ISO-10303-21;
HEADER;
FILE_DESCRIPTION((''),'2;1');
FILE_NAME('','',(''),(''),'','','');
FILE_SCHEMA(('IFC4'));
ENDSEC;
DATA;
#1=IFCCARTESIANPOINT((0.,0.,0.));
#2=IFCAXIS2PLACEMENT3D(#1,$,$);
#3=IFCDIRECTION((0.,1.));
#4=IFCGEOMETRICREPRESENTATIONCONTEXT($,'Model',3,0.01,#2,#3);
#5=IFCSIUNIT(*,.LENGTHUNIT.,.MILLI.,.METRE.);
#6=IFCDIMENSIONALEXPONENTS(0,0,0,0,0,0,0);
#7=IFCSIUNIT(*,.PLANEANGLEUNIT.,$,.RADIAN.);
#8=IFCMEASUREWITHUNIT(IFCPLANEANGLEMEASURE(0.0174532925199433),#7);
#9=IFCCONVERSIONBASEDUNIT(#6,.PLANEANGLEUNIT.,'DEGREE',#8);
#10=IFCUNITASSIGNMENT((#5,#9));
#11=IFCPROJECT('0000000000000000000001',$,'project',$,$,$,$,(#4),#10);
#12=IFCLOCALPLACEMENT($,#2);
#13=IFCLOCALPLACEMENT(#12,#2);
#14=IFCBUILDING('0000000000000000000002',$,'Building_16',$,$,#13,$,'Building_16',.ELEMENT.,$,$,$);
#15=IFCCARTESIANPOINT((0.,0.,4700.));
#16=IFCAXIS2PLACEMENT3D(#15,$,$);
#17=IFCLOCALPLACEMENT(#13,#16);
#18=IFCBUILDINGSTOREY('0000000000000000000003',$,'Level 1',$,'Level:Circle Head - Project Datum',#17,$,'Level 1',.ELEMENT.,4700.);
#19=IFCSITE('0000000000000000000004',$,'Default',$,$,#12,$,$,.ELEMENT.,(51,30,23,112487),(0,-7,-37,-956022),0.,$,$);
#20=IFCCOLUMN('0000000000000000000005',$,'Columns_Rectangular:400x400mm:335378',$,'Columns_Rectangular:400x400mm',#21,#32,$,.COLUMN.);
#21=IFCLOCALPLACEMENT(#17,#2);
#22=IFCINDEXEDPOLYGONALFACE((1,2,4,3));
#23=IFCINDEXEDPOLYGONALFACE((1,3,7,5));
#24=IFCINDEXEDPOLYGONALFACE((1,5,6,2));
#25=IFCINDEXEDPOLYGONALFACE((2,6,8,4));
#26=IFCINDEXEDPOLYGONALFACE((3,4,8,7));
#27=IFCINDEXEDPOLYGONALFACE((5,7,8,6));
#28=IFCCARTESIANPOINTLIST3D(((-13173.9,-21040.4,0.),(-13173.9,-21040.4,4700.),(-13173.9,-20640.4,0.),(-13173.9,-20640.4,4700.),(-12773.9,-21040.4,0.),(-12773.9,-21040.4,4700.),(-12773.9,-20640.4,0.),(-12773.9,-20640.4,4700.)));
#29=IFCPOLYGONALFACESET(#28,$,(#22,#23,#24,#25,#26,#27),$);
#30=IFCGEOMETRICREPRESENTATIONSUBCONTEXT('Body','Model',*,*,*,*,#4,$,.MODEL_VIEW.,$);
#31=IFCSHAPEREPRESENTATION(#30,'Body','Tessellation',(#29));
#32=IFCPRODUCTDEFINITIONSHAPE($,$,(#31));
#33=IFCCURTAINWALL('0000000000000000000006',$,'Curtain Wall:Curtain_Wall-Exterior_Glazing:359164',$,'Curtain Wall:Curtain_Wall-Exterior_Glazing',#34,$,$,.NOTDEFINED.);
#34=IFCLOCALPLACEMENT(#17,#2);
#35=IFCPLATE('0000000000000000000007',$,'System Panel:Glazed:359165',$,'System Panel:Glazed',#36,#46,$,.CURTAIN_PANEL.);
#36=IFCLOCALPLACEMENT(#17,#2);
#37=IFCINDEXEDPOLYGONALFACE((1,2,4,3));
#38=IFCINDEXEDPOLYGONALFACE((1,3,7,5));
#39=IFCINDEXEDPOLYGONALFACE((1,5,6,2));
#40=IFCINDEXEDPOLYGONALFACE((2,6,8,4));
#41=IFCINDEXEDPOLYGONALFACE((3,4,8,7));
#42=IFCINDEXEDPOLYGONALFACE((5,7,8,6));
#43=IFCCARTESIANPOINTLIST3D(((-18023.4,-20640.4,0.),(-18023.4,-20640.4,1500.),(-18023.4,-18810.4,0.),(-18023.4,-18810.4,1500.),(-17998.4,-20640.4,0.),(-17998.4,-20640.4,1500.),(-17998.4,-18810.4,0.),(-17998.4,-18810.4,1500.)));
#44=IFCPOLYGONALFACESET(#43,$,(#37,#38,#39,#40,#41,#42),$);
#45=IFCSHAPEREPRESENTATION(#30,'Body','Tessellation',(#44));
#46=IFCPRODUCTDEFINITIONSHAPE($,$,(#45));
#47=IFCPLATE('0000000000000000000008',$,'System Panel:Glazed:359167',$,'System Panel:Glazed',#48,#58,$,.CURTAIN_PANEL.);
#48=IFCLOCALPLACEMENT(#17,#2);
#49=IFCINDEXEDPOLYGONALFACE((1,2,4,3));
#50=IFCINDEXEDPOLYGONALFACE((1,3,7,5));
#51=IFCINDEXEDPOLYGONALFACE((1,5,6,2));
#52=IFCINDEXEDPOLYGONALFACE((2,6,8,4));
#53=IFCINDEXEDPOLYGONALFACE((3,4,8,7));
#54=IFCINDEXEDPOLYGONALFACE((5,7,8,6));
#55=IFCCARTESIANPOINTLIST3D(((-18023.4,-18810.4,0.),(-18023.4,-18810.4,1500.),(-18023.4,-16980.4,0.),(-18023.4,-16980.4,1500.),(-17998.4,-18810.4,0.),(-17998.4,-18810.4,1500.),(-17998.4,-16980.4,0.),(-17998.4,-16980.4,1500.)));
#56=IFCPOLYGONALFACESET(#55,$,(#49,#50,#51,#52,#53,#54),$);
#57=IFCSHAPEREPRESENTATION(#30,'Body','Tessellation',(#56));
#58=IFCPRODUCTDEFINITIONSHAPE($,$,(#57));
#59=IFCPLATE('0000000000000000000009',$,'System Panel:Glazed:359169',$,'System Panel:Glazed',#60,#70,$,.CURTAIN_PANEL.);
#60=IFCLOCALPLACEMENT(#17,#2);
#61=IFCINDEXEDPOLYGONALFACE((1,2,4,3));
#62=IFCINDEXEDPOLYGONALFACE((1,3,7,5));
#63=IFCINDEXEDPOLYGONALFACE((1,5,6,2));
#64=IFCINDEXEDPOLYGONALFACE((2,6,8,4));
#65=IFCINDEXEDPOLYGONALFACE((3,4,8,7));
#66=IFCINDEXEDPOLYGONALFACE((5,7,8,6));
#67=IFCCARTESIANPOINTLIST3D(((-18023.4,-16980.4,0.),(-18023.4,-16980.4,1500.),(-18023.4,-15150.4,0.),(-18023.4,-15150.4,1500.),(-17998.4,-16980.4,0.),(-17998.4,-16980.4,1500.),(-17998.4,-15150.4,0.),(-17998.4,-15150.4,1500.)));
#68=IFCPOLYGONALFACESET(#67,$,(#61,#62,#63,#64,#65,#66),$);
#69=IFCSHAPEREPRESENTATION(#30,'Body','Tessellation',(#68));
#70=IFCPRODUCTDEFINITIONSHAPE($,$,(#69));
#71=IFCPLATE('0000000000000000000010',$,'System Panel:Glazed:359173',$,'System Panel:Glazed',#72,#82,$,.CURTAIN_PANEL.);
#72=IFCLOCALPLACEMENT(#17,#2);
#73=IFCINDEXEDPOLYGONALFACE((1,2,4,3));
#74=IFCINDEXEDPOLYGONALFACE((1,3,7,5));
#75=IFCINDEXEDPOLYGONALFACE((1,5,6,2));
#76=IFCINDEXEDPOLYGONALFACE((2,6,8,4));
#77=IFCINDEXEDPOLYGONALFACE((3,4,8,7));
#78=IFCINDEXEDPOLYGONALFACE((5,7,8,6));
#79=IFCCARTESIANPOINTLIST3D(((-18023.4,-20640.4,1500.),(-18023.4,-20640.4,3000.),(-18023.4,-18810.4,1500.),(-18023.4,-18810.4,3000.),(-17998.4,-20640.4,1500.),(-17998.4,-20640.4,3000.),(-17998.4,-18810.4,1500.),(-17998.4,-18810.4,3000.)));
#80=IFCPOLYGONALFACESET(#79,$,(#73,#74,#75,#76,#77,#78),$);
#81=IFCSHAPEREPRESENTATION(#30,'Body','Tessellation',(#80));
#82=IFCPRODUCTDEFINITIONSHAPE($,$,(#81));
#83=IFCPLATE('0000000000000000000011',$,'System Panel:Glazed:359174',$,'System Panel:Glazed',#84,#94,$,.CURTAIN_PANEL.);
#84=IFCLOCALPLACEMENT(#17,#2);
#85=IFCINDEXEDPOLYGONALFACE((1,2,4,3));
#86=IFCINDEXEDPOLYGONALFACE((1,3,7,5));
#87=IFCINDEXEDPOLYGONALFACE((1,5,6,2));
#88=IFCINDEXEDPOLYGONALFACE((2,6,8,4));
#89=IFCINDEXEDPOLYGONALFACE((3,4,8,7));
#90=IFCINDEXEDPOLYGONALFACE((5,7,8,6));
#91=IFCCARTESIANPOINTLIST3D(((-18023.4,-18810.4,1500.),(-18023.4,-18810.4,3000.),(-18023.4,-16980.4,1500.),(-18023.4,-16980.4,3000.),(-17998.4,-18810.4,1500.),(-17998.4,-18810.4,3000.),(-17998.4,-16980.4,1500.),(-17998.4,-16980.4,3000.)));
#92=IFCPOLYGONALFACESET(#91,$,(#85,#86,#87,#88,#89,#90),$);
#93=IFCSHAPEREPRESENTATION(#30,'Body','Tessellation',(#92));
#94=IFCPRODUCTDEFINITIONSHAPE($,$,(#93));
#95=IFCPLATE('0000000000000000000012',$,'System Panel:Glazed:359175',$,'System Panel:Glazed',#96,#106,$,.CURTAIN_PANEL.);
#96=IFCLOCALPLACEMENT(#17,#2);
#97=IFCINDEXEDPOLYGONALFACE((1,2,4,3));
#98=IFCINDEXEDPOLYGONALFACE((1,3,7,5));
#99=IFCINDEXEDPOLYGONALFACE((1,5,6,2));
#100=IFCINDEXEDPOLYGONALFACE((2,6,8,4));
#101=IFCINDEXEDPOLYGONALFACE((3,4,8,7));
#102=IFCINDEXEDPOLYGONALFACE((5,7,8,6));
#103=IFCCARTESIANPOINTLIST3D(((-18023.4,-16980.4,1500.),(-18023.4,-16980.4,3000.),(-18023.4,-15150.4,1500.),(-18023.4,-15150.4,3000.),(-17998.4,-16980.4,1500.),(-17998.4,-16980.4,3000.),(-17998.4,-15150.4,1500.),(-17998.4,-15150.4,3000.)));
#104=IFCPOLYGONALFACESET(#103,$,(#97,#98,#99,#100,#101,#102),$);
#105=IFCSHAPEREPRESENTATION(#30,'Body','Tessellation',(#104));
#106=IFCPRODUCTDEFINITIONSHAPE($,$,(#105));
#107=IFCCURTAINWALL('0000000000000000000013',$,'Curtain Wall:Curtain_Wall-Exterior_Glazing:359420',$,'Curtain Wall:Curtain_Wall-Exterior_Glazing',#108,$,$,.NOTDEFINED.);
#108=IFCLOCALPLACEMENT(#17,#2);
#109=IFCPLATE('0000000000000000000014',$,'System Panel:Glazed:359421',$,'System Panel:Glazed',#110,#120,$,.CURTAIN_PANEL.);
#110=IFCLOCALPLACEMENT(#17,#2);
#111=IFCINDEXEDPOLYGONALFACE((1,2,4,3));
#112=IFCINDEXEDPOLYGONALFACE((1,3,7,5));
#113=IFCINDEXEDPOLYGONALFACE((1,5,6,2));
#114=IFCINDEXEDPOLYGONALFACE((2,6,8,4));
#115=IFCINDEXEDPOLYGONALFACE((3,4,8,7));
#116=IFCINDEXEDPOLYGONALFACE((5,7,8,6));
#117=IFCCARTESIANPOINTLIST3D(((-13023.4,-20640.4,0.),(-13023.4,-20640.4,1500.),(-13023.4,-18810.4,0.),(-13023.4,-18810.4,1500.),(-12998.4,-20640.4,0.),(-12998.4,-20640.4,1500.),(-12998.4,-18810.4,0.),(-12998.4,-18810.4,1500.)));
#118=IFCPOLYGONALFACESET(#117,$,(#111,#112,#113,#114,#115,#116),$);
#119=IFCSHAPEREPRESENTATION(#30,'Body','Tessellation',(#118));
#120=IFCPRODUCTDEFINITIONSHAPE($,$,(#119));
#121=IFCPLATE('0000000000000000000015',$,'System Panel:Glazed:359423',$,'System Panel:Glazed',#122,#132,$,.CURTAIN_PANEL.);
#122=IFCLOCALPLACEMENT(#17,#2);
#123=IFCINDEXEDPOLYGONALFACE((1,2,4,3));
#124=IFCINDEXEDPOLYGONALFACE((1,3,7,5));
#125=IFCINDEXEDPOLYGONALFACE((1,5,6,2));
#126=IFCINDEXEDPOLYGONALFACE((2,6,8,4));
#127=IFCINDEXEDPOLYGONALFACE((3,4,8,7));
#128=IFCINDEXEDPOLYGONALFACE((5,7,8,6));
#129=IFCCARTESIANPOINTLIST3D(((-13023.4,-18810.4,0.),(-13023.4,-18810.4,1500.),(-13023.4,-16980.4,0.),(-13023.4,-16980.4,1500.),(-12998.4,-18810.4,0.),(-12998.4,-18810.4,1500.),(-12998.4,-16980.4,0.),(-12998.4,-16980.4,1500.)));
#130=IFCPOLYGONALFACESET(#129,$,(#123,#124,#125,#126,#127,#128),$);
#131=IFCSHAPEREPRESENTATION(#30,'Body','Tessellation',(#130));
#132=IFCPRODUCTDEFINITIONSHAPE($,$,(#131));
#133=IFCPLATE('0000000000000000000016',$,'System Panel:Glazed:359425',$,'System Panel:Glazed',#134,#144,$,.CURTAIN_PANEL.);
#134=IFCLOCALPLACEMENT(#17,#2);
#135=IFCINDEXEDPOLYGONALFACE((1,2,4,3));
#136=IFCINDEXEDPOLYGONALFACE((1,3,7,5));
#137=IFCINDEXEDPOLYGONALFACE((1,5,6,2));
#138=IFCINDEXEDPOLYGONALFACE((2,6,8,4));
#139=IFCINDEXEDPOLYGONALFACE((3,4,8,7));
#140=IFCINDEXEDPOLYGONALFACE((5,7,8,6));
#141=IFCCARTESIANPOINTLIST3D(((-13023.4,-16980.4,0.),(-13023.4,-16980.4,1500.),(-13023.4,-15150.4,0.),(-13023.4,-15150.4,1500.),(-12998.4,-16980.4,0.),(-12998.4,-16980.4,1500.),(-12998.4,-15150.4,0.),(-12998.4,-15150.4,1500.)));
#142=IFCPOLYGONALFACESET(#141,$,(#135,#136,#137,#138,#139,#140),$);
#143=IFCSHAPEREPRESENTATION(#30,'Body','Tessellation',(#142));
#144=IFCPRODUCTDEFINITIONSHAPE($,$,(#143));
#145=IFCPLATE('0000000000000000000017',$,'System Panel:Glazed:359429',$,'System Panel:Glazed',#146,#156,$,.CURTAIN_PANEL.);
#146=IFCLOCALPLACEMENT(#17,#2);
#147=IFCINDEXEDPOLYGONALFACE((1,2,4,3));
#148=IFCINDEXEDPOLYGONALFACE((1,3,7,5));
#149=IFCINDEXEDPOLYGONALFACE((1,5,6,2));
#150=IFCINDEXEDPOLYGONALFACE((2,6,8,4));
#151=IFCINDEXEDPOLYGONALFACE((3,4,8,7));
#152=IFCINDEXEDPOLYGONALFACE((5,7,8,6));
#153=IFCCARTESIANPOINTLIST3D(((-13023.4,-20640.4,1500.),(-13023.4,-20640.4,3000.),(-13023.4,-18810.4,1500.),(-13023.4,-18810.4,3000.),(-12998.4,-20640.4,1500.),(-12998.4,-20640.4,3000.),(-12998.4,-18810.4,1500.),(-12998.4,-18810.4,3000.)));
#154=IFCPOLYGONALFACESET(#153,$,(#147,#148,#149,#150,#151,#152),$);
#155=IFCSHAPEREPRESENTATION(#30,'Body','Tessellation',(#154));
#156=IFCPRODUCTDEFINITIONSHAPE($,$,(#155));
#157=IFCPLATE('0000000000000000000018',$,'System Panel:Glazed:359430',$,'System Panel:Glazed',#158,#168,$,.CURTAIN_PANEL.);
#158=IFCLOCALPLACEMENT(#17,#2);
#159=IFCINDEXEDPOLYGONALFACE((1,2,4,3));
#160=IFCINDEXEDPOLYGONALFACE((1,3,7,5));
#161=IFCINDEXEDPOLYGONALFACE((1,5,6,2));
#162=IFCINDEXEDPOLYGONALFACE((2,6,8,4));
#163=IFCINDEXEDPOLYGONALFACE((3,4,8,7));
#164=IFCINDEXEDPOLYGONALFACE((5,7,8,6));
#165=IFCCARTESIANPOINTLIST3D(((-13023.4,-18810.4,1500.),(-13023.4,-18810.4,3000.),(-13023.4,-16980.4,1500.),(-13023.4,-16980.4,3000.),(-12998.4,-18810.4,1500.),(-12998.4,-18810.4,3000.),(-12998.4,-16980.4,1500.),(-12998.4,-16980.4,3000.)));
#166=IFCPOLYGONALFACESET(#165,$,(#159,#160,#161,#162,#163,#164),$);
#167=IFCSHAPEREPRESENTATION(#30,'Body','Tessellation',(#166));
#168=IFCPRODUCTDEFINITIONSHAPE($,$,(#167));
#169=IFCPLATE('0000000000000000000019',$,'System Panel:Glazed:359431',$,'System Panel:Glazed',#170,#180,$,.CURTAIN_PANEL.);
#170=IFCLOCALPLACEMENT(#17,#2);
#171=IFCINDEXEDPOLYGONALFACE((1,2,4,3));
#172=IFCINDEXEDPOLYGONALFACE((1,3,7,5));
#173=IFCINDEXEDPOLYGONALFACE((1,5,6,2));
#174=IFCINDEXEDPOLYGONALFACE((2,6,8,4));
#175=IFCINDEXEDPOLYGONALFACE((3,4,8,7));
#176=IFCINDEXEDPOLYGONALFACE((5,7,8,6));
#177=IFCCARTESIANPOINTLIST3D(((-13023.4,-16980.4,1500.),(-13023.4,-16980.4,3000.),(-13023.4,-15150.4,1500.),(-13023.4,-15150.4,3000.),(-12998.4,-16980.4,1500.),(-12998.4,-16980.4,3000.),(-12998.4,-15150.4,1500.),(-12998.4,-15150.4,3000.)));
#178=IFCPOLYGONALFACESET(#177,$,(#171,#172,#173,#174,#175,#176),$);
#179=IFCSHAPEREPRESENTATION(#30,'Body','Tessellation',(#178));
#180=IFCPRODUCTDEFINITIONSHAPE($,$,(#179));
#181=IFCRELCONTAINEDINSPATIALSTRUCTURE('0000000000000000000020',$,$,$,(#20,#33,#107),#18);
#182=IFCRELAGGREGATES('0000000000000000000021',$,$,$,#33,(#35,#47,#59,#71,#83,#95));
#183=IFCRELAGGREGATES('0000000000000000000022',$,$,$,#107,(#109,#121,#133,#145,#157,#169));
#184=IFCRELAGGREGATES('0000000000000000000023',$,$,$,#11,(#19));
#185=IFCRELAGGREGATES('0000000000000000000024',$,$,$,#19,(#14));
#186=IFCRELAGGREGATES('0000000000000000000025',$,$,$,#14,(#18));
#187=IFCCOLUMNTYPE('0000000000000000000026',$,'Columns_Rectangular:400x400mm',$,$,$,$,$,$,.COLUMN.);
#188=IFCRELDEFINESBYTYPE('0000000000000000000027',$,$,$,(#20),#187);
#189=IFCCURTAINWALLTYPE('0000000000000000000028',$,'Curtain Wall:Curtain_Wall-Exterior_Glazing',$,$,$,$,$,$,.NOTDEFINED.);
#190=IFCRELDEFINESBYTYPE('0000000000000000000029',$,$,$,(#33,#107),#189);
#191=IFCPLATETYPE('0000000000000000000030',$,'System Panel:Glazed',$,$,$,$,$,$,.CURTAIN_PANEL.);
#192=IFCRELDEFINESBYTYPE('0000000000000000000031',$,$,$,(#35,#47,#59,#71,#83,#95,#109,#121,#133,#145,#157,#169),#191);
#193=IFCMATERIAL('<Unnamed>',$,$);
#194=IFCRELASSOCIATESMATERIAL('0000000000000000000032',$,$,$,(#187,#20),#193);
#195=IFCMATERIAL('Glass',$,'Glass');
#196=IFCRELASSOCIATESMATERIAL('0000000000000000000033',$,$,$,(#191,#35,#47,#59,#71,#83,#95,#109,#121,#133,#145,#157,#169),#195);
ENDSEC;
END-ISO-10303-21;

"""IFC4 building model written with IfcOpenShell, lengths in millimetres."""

from ifc_helpers import new_model, entity, si_unit, converted_unit, direction, frame, origin, place, context, subcontext, project, spatial, indexed_curve, outline, extrude, source, transform, mapped, material, type_object, type_shapes, element, aggregate, save


model = new_model("IFC4")

# Units and contexts
model_context = context("Model", 3, precision=0.01, world=origin(), true_north=direction((0.0, 1.0)))
body_context = subcontext(model_context, "Body", "Model", "MODEL_VIEW")
ifc_project = project(units=[si_unit("LENGTHUNIT", "METRE", prefix="MILLI"), converted_unit("PLANEANGLEUNIT", "DEGREE", entity("IfcPlaneAngleMeasure", 0.0174532925199433), si_unit("PLANEANGLEUNIT", "RADIAN"), dimensions=[0, 0, 0, 0, 0, 0, 0])], contexts=[model_context])

# Site, building, storey
site_placement = place(None, origin())
site = spatial("IfcSite", under=ifc_project, at=site_placement, Name="Default", CompositionType="ELEMENT", RefLatitude=(51, 30, 23, 112487), RefLongitude=(0, -7, -37, -956022), RefElevation=0.0)
building_placement = place(site_placement, origin())
building = spatial("IfcBuilding", under=site, at=building_placement, Name="Building_16", LongName="Building_16", CompositionType="ELEMENT")
storey_placement = place(building_placement, frame((0.0, 0.0, 4700.0)))
storey = spatial("IfcBuildingStorey", under=building, at=storey_placement, Name="Level 1", ObjectType="Level:Circle Head - Project Datum", LongName="Level 1", CompositionType="ELEMENT", Elevation=4700.0)

# Column
ifc_material_1 = material(Name="<Unnamed>")
column_type = type_object("IfcColumnType", Name="Columns_Rectangular:400x400mm", PredefinedType="COLUMN", material=ifc_material_1)
shared_shape_1 = source(origin(), body_context, "Body", "SweptSolid", [
    extrude(outline(indexed_curve([(-200.0, -200.0), (200.0, -200.0), (200.0, 200.0), (-200.0, 200.0), (-200.0, -200.0)], self_intersect=False)), frame((0.0, 0.0, 4700.0), z_axis=(0.0, 0.0, 1.0), x_axis=(-1.0, 0.0, 0.0)), (0.0, 0.0, 1.0), 4700.0),
])
type_shapes(column_type, [shared_shape_1])
column_placement = place(storey_placement, frame((-12973.9, -20840.4, -4700.0)))
element("IfcColumn", 1, at=column_placement, inside=storey, type_object=column_type, material=ifc_material_1, Name="Columns_Rectangular:400x400mm:335378", ObjectType="Columns_Rectangular:400x400mm", PredefinedType="COLUMN", context=body_context, shape_type="MappedRepresentation", body=[
    mapped(shared_shape_1, transform((0.0, 0.0, 0.0), scale=1.0)),
])

# Curtain walls, plates
curtain_wall_type = type_object("IfcCurtainWallType", Name="Curtain Wall:Curtain_Wall-Exterior_Glazing", PredefinedType="NOTDEFINED")
curtain_wall_1_placement = place(storey_placement, frame((0.0, 0.0, -4700.0)))
curtain_wall_1 = element("IfcCurtainWall", 2, at=curtain_wall_1_placement, inside=storey, type_object=curtain_wall_type, Name="Curtain Wall:Curtain_Wall-Exterior_Glazing:359164", ObjectType="Curtain Wall:Curtain_Wall-Exterior_Glazing", PredefinedType="NOTDEFINED")
ifc_material_2 = material(Name="Glass", Category="Glass")
plate_type_1 = type_object("IfcPlateType", Name="System Panel:Glazed", PredefinedType="CURTAIN_PANEL", material=ifc_material_2)
shared_shape_2 = source(origin(), body_context, "Body", "SweptSolid", [
    extrude(outline(indexed_curve([(-12.5, -915.0), (12.5, -915.0), (12.5, 915.0), (-12.5, 915.0), (-12.5, -915.0)], self_intersect=False)), frame((0.0, 37.0, 0.0), z_axis=(0.0, 0.0, 1.0), x_axis=(0.0, 1.0, 0.0)), (0.0, 0.0, 1.0), 1500.0),
])
type_shapes(plate_type_1, [shared_shape_2])
plate_1_placement = place(curtain_wall_1_placement, frame((-17973.9, -19725.4, 4700.0), z_axis=(0.0, 0.0, 1.0), x_axis=(0.0, 1.0, 0.0)))
plate_1 = element("IfcPlate", 3, at=plate_1_placement, type_object=plate_type_1, material=ifc_material_2, Name="System Panel:Glazed:359165", ObjectType="System Panel:Glazed", PredefinedType="CURTAIN_PANEL", context=body_context, shape_type="MappedRepresentation", body=[
    mapped(shared_shape_2, transform((0.0, 0.0, 0.0), scale=1.0)),
])
plate_2_placement = place(curtain_wall_1_placement, frame((-17973.9, -17895.4, 4700.0), z_axis=(0.0, 0.0, 1.0), x_axis=(0.0, 1.0, 0.0)))
plate_2 = element("IfcPlate", 4, at=plate_2_placement, type_object=plate_type_1, material=ifc_material_2, Name="System Panel:Glazed:359167", ObjectType="System Panel:Glazed", PredefinedType="CURTAIN_PANEL", context=body_context, shape_type="MappedRepresentation", body=[
    mapped(shared_shape_2, transform((0.0, 0.0, 0.0), scale=1.0)),
])
plate_3_placement = place(curtain_wall_1_placement, frame((-17973.9, -16065.4, 4700.0), z_axis=(0.0, 0.0, 1.0), x_axis=(0.0, 1.0, 0.0)))
plate_3 = element("IfcPlate", 5, at=plate_3_placement, type_object=plate_type_1, material=ifc_material_2, Name="System Panel:Glazed:359169", ObjectType="System Panel:Glazed", PredefinedType="CURTAIN_PANEL", context=body_context, shape_type="MappedRepresentation", body=[
    mapped(shared_shape_2, transform((0.0, 0.0, 0.0), scale=1.0)),
])
plate_4_placement = place(curtain_wall_1_placement, frame((-17973.9, -19725.4, 6200.0), z_axis=(0.0, 0.0, 1.0), x_axis=(0.0, 1.0, 0.0)))
plate_4 = element("IfcPlate", 6, at=plate_4_placement, type_object=plate_type_1, material=ifc_material_2, Name="System Panel:Glazed:359173", ObjectType="System Panel:Glazed", PredefinedType="CURTAIN_PANEL", context=body_context, shape_type="MappedRepresentation", body=[
    mapped(shared_shape_2, transform((0.0, 0.0, 0.0), scale=1.0)),
])
plate_5_placement = place(curtain_wall_1_placement, frame((-17973.9, -17895.4, 6200.0), z_axis=(0.0, 0.0, 1.0), x_axis=(0.0, 1.0, 0.0)))
plate_5 = element("IfcPlate", 7, at=plate_5_placement, type_object=plate_type_1, material=ifc_material_2, Name="System Panel:Glazed:359174", ObjectType="System Panel:Glazed", PredefinedType="CURTAIN_PANEL", context=body_context, shape_type="MappedRepresentation", body=[
    mapped(shared_shape_2, transform((0.0, 0.0, 0.0), scale=1.0)),
])
plate_6_placement = place(curtain_wall_1_placement, frame((-17973.9, -16065.4, 6200.0), z_axis=(0.0, 0.0, 1.0), x_axis=(0.0, 1.0, 0.0)))
plate_6 = element("IfcPlate", 8, at=plate_6_placement, type_object=plate_type_1, material=ifc_material_2, Name="System Panel:Glazed:359175", ObjectType="System Panel:Glazed", PredefinedType="CURTAIN_PANEL", context=body_context, shape_type="MappedRepresentation", body=[
    mapped(shared_shape_2, transform((0.0, 0.0, 0.0), scale=1.0)),
])
curtain_wall_2_placement = place(storey_placement, frame((0.0, 0.0, -4700.0)))
curtain_wall_2 = element("IfcCurtainWall", 9, at=curtain_wall_2_placement, inside=storey, type_object=curtain_wall_type, Name="Curtain Wall:Curtain_Wall-Exterior_Glazing:359420", ObjectType="Curtain Wall:Curtain_Wall-Exterior_Glazing", PredefinedType="NOTDEFINED")
plate_7_placement = place(curtain_wall_2_placement, frame((-12973.9, -19725.4, 4700.0), z_axis=(0.0, 0.0, 1.0), x_axis=(0.0, 1.0, 0.0)))
plate_7 = element("IfcPlate", 10, at=plate_7_placement, type_object=plate_type_1, material=ifc_material_2, Name="System Panel:Glazed:359421", ObjectType="System Panel:Glazed", PredefinedType="CURTAIN_PANEL", context=body_context, shape_type="MappedRepresentation", body=[
    mapped(shared_shape_2, transform((0.0, 0.0, 0.0), scale=1.0)),
])
plate_8_placement = place(curtain_wall_2_placement, frame((-12973.9, -17895.4, 4700.0), z_axis=(0.0, 0.0, 1.0), x_axis=(0.0, 1.0, 0.0)))
plate_8 = element("IfcPlate", 11, at=plate_8_placement, type_object=plate_type_1, material=ifc_material_2, Name="System Panel:Glazed:359423", ObjectType="System Panel:Glazed", PredefinedType="CURTAIN_PANEL", context=body_context, shape_type="MappedRepresentation", body=[
    mapped(shared_shape_2, transform((0.0, 0.0, 0.0), scale=1.0)),
])
plate_9_placement = place(curtain_wall_2_placement, frame((-12973.9, -16065.4, 4700.0), z_axis=(0.0, 0.0, 1.0), x_axis=(0.0, 1.0, 0.0)))
plate_9 = element("IfcPlate", 12, at=plate_9_placement, type_object=plate_type_1, material=ifc_material_2, Name="System Panel:Glazed:359425", ObjectType="System Panel:Glazed", PredefinedType="CURTAIN_PANEL", context=body_context, shape_type="MappedRepresentation", body=[
    mapped(shared_shape_2, transform((0.0, 0.0, 0.0), scale=1.0)),
])
plate_10_placement = place(curtain_wall_2_placement, frame((-12973.9, -19725.4, 6200.0), z_axis=(0.0, 0.0, 1.0), x_axis=(0.0, 1.0, 0.0)))
plate_10 = element("IfcPlate", 13, at=plate_10_placement, type_object=plate_type_1, material=ifc_material_2, Name="System Panel:Glazed:359429", ObjectType="System Panel:Glazed", PredefinedType="CURTAIN_PANEL", context=body_context, shape_type="MappedRepresentation", body=[
    mapped(shared_shape_2, transform((0.0, 0.0, 0.0), scale=1.0)),
])
plate_11_placement = place(curtain_wall_2_placement, frame((-12973.9, -17895.4, 6200.0), z_axis=(0.0, 0.0, 1.0), x_axis=(0.0, 1.0, 0.0)))
plate_11 = element("IfcPlate", 14, at=plate_11_placement, type_object=plate_type_1, material=ifc_material_2, Name="System Panel:Glazed:359430", ObjectType="System Panel:Glazed", PredefinedType="CURTAIN_PANEL", context=body_context, shape_type="MappedRepresentation", body=[
    mapped(shared_shape_2, transform((0.0, 0.0, 0.0), scale=1.0)),
])
plate_12_placement = place(curtain_wall_2_placement, frame((-12973.9, -16065.4, 6200.0), z_axis=(0.0, 0.0, 1.0), x_axis=(0.0, 1.0, 0.0)))
plate_12 = element("IfcPlate", 15, at=plate_12_placement, type_object=plate_type_1, material=ifc_material_2, Name="System Panel:Glazed:359431", ObjectType="System Panel:Glazed", PredefinedType="CURTAIN_PANEL", context=body_context, shape_type="MappedRepresentation", body=[
    mapped(shared_shape_2, transform((0.0, 0.0, 0.0), scale=1.0)),
])

aggregate(curtain_wall_1, [plate_1, plate_2, plate_3, plate_4, plate_5, plate_6])
aggregate(curtain_wall_2, [plate_7, plate_8, plate_9, plate_10, plate_11, plate_12])

save(model, "model.ifc")
